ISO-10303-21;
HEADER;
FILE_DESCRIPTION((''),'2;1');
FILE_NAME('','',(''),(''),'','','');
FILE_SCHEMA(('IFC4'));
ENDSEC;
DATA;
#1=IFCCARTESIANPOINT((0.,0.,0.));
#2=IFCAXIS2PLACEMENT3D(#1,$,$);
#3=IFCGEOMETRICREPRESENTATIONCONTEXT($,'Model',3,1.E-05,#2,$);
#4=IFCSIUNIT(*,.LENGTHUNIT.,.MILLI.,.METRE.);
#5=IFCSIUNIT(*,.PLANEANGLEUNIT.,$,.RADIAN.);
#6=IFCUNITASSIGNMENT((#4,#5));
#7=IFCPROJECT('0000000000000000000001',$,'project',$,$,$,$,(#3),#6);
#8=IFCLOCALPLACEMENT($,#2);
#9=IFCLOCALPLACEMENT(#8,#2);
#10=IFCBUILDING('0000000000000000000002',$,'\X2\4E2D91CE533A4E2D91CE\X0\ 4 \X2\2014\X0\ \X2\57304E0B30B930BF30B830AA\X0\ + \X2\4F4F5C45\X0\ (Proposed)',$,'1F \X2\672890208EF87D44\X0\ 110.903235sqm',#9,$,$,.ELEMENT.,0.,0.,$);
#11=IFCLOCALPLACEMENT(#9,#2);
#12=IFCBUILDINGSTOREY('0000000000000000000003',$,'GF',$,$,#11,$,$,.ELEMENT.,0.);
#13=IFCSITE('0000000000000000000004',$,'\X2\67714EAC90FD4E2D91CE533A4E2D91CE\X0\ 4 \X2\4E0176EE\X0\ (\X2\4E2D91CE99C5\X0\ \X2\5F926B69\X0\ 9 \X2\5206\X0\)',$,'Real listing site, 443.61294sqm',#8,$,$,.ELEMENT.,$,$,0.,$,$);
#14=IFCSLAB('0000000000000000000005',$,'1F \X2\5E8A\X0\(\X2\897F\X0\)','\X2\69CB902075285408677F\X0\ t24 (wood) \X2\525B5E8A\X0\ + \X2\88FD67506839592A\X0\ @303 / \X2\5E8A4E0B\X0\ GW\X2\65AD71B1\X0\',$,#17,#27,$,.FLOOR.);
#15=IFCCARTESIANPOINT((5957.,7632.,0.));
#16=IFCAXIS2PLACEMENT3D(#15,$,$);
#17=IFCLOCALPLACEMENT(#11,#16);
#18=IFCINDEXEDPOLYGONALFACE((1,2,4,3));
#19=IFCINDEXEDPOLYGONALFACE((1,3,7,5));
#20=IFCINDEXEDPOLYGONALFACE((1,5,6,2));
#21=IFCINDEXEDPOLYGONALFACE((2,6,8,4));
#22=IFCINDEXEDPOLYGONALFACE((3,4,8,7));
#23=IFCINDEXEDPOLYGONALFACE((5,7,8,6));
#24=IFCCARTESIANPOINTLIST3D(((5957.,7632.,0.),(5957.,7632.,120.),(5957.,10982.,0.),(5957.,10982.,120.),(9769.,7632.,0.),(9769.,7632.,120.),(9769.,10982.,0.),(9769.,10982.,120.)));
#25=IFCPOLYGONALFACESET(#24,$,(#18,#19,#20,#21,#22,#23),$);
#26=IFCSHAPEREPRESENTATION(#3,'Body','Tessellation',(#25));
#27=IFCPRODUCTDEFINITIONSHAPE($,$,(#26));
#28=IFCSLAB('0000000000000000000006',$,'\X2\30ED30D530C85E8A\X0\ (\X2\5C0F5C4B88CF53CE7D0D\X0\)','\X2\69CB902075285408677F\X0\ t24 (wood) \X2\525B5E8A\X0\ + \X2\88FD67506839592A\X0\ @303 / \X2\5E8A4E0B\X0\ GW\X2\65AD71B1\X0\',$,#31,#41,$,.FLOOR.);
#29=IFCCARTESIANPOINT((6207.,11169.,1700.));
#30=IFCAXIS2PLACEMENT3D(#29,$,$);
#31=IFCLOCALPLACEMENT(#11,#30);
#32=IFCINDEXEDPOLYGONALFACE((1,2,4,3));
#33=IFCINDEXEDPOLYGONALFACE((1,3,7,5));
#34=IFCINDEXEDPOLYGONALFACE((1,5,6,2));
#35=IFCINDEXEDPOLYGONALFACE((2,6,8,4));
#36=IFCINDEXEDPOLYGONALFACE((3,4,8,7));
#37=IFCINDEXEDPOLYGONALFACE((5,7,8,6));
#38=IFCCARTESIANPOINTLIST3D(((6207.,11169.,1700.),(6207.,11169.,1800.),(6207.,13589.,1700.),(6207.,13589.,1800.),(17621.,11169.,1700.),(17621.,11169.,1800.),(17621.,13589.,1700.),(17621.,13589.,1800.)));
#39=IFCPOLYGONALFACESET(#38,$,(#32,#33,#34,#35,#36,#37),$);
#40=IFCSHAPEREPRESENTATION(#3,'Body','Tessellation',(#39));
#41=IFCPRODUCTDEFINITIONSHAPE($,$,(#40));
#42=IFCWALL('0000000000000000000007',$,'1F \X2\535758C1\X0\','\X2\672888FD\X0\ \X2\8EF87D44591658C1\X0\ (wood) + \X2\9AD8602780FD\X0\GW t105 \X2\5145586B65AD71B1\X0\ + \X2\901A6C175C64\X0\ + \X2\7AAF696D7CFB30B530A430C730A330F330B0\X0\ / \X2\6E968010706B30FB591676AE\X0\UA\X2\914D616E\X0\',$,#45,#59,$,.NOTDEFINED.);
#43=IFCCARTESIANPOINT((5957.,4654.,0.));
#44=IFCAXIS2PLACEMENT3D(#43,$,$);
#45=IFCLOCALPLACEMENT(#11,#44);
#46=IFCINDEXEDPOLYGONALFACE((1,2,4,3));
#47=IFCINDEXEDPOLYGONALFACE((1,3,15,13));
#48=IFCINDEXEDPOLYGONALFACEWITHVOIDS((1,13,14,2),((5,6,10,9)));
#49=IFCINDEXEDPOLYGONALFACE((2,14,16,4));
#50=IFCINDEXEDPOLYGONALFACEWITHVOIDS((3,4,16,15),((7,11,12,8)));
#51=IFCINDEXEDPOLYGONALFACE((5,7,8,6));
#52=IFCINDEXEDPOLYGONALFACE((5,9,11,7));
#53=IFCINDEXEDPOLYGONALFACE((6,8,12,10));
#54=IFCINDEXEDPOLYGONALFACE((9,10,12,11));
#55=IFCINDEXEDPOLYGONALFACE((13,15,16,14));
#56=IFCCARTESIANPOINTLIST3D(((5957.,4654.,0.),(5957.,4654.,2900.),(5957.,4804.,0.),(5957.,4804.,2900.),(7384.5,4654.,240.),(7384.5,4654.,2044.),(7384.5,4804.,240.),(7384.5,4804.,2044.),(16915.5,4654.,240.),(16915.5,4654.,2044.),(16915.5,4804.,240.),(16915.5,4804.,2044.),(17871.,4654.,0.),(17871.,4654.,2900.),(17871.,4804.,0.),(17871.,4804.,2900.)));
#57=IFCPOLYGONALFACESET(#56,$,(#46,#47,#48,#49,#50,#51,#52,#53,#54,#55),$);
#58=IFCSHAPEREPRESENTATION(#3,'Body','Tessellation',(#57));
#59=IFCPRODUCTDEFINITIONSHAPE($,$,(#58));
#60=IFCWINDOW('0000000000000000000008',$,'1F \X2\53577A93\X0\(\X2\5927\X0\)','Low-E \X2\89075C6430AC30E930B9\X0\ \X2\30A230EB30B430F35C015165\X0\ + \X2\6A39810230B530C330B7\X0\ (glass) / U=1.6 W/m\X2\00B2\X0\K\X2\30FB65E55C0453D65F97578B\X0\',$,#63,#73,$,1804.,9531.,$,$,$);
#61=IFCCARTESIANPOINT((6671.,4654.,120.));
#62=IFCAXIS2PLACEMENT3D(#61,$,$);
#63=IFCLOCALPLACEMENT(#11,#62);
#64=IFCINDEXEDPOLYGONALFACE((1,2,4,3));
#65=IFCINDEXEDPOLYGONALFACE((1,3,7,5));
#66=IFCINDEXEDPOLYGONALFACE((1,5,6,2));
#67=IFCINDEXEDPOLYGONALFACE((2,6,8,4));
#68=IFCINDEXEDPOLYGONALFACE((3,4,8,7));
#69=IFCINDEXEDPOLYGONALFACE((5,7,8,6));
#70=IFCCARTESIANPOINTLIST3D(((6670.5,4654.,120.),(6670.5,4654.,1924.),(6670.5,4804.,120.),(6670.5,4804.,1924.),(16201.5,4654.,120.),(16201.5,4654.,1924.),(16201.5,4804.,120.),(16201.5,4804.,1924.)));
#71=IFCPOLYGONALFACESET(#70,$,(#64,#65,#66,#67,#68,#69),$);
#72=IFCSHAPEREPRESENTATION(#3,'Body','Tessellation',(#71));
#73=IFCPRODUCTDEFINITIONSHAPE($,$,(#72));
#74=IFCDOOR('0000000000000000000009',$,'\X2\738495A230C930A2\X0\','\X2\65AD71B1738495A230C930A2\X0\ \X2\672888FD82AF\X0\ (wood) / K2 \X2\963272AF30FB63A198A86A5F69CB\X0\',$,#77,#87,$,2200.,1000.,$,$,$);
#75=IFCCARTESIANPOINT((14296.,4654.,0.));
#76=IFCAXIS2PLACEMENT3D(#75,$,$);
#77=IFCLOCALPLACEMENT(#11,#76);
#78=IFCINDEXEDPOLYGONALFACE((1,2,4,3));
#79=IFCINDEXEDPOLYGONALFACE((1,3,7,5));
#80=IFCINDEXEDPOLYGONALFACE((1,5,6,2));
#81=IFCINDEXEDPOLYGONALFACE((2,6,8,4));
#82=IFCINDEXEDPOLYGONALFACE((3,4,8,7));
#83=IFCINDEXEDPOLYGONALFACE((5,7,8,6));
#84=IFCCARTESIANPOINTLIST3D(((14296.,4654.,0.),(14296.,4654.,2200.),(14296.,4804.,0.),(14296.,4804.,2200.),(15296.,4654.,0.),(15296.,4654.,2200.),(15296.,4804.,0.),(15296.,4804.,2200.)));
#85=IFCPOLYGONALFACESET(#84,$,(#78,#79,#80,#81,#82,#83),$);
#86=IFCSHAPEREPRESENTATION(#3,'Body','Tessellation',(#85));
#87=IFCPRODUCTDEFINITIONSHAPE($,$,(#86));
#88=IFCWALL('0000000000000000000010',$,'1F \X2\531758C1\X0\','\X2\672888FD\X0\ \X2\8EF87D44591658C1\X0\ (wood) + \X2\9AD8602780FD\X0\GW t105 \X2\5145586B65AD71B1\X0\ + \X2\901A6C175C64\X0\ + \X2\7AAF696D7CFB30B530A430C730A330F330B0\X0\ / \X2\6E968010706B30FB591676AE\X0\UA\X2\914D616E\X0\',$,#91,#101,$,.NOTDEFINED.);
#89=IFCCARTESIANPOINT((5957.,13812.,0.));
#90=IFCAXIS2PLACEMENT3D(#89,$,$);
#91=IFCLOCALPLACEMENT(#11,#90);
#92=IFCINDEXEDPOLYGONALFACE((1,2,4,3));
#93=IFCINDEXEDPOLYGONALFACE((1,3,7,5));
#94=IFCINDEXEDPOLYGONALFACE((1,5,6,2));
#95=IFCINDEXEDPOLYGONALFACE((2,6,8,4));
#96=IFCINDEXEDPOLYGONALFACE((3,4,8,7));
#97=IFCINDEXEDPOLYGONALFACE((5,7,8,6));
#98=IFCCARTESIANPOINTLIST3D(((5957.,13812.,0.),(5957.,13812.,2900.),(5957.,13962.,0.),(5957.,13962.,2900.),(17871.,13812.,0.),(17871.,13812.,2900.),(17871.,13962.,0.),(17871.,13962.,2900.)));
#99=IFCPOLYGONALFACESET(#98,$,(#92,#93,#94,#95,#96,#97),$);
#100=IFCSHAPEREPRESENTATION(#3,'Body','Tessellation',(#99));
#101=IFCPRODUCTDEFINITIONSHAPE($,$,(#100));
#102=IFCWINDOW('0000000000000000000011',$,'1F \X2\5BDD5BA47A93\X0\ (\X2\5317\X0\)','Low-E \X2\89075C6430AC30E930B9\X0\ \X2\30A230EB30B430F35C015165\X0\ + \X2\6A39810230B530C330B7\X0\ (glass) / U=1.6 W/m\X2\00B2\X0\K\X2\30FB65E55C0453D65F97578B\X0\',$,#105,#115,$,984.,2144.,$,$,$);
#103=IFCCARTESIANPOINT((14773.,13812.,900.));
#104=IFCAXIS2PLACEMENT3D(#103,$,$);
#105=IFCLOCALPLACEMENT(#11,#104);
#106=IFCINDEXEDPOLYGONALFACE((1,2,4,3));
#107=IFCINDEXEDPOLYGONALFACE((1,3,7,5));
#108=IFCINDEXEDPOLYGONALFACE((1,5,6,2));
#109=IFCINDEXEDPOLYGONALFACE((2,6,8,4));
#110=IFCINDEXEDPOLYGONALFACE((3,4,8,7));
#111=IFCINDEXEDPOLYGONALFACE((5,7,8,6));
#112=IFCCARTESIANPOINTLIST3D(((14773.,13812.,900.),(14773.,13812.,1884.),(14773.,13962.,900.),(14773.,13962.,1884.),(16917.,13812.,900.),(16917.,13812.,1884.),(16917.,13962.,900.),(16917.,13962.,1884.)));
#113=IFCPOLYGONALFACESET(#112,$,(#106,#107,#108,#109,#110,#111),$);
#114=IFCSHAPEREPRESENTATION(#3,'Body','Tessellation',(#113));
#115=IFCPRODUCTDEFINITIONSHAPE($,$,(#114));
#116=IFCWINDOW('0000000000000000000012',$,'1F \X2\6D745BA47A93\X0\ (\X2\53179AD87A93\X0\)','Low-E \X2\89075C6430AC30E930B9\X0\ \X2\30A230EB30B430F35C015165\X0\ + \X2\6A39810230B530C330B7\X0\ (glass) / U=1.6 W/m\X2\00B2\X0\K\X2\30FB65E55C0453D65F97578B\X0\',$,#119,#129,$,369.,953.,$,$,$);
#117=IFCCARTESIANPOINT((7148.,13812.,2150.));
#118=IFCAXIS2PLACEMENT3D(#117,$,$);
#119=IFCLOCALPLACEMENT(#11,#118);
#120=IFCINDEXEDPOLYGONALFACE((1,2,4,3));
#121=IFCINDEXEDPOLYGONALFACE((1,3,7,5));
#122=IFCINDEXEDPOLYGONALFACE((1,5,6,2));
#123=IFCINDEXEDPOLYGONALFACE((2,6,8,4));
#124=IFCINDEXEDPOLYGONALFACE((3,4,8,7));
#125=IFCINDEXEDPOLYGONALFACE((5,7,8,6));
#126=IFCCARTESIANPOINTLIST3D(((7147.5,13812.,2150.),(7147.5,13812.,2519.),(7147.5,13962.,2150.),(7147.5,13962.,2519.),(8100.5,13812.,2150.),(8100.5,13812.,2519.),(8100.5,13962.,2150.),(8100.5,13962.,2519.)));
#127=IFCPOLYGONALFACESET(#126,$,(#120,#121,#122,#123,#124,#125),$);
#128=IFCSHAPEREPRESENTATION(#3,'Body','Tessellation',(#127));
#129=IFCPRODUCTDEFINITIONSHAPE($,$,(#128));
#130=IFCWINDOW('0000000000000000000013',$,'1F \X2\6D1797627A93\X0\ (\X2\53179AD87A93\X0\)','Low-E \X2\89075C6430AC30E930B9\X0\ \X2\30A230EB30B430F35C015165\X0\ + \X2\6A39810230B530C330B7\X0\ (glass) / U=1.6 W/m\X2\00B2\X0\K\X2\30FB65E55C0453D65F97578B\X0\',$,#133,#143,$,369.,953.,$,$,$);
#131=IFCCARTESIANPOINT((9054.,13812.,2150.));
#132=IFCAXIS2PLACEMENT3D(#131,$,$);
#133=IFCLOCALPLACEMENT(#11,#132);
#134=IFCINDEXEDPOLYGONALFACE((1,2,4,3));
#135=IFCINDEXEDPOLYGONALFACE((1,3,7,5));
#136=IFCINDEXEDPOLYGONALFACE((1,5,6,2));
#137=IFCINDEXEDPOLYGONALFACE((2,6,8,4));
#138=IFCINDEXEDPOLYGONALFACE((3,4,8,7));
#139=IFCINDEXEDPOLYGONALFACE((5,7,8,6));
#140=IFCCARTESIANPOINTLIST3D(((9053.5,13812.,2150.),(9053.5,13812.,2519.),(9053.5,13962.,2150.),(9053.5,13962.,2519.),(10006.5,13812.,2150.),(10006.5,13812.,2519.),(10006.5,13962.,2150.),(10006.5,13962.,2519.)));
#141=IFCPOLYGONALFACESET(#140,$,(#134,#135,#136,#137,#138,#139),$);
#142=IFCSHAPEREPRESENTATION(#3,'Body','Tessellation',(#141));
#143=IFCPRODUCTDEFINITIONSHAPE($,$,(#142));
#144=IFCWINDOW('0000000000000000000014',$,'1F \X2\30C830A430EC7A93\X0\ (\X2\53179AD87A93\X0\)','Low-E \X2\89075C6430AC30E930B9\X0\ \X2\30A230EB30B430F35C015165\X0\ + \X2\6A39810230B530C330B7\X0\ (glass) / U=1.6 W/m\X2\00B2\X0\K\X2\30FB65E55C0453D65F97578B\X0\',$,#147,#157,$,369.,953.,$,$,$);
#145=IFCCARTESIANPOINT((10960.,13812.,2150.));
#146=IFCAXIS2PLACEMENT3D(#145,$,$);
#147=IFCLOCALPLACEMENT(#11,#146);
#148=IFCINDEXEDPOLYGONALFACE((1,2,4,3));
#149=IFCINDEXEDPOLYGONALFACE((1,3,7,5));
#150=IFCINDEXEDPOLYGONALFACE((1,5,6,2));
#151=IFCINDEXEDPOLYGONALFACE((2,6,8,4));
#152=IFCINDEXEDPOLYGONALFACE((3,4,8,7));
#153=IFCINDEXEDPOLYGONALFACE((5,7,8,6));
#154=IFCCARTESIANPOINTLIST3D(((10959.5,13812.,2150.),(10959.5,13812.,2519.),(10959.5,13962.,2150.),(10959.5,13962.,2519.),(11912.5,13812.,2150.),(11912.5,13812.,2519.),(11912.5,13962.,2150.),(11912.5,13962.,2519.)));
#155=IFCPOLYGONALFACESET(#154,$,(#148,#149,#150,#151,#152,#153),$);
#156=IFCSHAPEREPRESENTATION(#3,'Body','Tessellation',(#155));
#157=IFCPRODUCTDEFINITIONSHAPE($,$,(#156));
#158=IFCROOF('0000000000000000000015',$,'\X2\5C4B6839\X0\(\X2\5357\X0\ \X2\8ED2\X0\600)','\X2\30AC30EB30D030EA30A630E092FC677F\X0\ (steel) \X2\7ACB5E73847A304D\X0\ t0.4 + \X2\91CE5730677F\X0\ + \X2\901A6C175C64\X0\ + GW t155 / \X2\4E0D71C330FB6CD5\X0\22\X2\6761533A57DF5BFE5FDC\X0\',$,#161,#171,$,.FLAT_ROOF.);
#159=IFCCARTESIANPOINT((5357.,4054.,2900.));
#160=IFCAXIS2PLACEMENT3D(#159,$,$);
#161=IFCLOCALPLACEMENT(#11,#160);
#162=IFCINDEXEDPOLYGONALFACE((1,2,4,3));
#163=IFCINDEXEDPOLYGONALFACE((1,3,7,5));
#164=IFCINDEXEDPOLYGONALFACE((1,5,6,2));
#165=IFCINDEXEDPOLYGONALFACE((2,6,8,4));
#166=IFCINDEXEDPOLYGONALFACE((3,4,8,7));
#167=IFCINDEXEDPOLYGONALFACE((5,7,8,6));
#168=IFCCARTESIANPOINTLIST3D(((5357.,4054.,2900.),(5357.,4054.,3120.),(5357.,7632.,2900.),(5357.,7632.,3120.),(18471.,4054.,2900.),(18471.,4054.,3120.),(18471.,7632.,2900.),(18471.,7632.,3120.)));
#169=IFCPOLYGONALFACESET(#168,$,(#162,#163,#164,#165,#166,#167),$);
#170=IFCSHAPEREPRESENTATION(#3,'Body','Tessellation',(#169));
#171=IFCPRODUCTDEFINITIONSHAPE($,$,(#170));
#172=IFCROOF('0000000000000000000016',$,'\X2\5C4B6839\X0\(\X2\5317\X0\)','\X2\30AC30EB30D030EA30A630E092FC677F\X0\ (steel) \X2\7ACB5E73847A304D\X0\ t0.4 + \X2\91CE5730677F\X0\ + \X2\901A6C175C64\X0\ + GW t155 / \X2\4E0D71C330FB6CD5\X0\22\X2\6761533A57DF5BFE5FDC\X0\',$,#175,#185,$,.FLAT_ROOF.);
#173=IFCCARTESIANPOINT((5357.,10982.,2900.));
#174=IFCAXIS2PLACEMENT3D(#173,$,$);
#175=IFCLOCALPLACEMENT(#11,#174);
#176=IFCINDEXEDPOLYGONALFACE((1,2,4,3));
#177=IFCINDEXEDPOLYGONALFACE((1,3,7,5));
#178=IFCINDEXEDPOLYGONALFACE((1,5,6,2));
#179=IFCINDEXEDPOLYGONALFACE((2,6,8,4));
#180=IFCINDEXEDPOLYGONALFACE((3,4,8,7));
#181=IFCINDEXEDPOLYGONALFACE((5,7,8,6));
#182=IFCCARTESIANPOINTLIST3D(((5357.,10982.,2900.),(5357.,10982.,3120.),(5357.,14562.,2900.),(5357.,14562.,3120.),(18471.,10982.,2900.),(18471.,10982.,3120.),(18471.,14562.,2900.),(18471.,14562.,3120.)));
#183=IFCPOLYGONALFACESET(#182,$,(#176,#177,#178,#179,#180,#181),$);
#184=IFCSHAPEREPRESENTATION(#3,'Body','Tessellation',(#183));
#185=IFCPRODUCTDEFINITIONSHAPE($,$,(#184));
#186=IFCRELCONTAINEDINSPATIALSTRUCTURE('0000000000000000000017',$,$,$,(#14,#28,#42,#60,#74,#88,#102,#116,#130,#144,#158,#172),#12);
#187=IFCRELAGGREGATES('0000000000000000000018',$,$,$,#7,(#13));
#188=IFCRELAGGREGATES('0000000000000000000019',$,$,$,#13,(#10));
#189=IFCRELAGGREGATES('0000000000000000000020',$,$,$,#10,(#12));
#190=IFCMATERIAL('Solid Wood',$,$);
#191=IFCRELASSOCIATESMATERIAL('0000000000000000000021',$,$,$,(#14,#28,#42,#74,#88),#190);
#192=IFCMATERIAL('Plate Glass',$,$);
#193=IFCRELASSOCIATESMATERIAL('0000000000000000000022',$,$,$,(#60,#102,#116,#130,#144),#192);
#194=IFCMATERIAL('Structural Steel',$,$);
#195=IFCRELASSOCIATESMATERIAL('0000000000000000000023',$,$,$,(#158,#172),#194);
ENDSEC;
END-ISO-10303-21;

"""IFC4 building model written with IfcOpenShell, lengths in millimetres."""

from ifc_helpers import new_model, si_unit, frame, frame_2d, origin, place, context, project, spatial, rectangle, extrude, material, element, fill, save


model = new_model("IFC4")

# Units and contexts
model_context = context("Model", 3, precision=1e-05, world=origin())
ifc_project = project(units=[si_unit("LENGTHUNIT", "METRE", prefix="MILLI"), si_unit("PLANEANGLEUNIT", "RADIAN")], contexts=[model_context])

# Site, building, storey
site_placement = place(None, origin())
site = spatial("IfcSite", under=ifc_project, at=site_placement, Name="東京都中野区中野 4 丁目 (中野駅 徒歩 9 分)", ObjectType="Real listing site, 443.61294sqm", CompositionType="ELEMENT", RefElevation=0.0)
building_placement = place(site_placement, origin())
building = spatial("IfcBuilding", under=site, at=building_placement, Name="中野区中野 4 — 地下スタジオ + 住居 (Proposed)", ObjectType="1F 木造軸組 110.903235sqm", CompositionType="ELEMENT", ElevationOfRefHeight=0.0, ElevationOfTerrain=0.0)
storey_placement = place(building_placement, origin())
storey = spatial("IfcBuildingStorey", under=building, at=storey_placement, Name="GF", CompositionType="ELEMENT", Elevation=0.0)

# Slabs
ifc_material_1 = material(Name="Solid Wood")
slab_1_placement = place(storey_placement, frame((5957.0, 7632.0, 0.0)))
element("IfcSlab", 1, at=slab_1_placement, inside=storey, material=ifc_material_1, Name="1F 床(西)", Description="構造用合板 t24 (wood) 剛床 + 製材根太 @303 / 床下 GW断熱", PredefinedType="FLOOR", context=model_context, shape_type="SweptSolid", body=[
    extrude(rectangle(XDim=3812.0, YDim=3350.0, at=frame_2d((1906.0, 1675.0))), frame((5957.0, 7632.0, 0.0)), (0.0, 0.0, 1.0), 120.0),
])
slab_2_placement = place(storey_placement, frame((6207.0, 11169.0, 1700.0)))
element("IfcSlab", 2, at=slab_2_placement, inside=storey, material=ifc_material_1, Name="ロフト床 (小屋裏収納)", Description="構造用合板 t24 (wood) 剛床 + 製材根太 @303 / 床下 GW断熱", PredefinedType="FLOOR", context=model_context, shape_type="SweptSolid", body=[
    extrude(rectangle(XDim=11414.0, YDim=2420.0, at=frame_2d((5707.0, 1210.0))), frame((6207.0, 11169.0, 1700.0)), (0.0, 0.0, 1.0), 100.0),
])

# Wall, openings, window, door
wall_1_placement = place(storey_placement, frame((5957.0, 4654.0, 0.0)))
wall_1 = element("IfcWall", 3, at=wall_1_placement, inside=storey, material=ifc_material_1, Name="1F 南壁", Description="木製 軸組外壁 (wood) + 高性能GW t105 充填断熱 + 通気層 + 窯業系サイディング / 準耐火・外皮UA配慮", PredefinedType="NOTDEFINED", context=model_context, shape_type="SweptSolid", body=[
    extrude(rectangle(XDim=11914.0, YDim=150.0, at=frame_2d((5957.0, 75.0))), frame((5957.0, 4654.0, 0.0)), (0.0, 0.0, 1.0), 2900.0),
])
opening_1_placement = place(storey_placement, frame((6671.0, 4654.0, 120.0)))
opening_1 = element("IfcOpeningElement", 4, at=opening_1_placement, cuts=wall_1, PredefinedType="NOTDEFINED", context=model_context, shape_type="SweptSolid", body=[
    extrude(rectangle(XDim=9531.0, YDim=150.0, at=frame_2d((4765.0, 75.0))), frame((6671.0, 4654.0, 120.0)), (0.0, 0.0, 1.0), 1804.0),
])
opening_2_placement = place(storey_placement, frame((14296.0, 4654.0, 0.0)))
opening_2 = element("IfcOpeningElement", 5, at=opening_2_placement, cuts=wall_1, PredefinedType="NOTDEFINED", context=model_context, shape_type="SweptSolid", body=[
    extrude(rectangle(XDim=1000.0, YDim=150.0, at=frame_2d((500.0, 75.0))), frame((14296.0, 4654.0, 0.0)), (0.0, 0.0, 1.0), 2200.0),
])
ifc_material_2 = material(Name="Plate Glass")
window_1_placement = place(storey_placement, frame((6671.0, 4654.0, 120.0)))
window_1 = element("IfcWindow", 6, at=window_1_placement, inside=storey, material=ifc_material_2, Name="1F 南窓(大)", Description="Low-E 複層ガラス アルゴン封入 + 樹脂サッシ (glass) / U=1.6 W/m²K・日射取得型", OverallHeight=1804.0, OverallWidth=9531.0, context=model_context, shape_type="SweptSolid", body=[
    extrude(rectangle(XDim=9531.0, YDim=150.0, at=frame_2d((4765.0, 75.0))), frame((6671.0, 4654.0, 120.0)), (0.0, 0.0, 1.0), 1804.0),
])
fill(opening_1, window_1)
door_1_placement = place(storey_placement, frame((14296.0, 4654.0, 0.0)))
door_1 = element("IfcDoor", 7, at=door_1_placement, inside=storey, material=ifc_material_1, Name="玄関ドア", Description="断熱玄関ドア 木製芯 (wood) / K2 防犯・採風機構", OverallHeight=2200.0, OverallWidth=1000.0, context=model_context, shape_type="SweptSolid", body=[
    extrude(rectangle(XDim=1000.0, YDim=150.0, at=frame_2d((500.0, 75.0))), frame((14296.0, 4654.0, 0.0)), (0.0, 0.0, 1.0), 2200.0),
])
fill(opening_2, door_1)

# Wall, openings, windows
wall_2_placement = place(storey_placement, frame((5957.0, 13812.0, 0.0)))
wall_2 = element("IfcWall", 8, at=wall_2_placement, inside=storey, material=ifc_material_1, Name="1F 北壁", Description="木製 軸組外壁 (wood) + 高性能GW t105 充填断熱 + 通気層 + 窯業系サイディング / 準耐火・外皮UA配慮", PredefinedType="NOTDEFINED", context=model_context, shape_type="SweptSolid", body=[
    extrude(rectangle(XDim=11914.0, YDim=150.0, at=frame_2d((5957.0, 75.0))), frame((5957.0, 13812.0, 0.0)), (0.0, 0.0, 1.0), 2900.0),
])
opening_3_placement = place(storey_placement, frame((14773.0, 13812.0, 900.0)))
opening_3 = element("IfcOpeningElement", 9, at=opening_3_placement, cuts=wall_2, PredefinedType="NOTDEFINED", context=model_context, shape_type="SweptSolid", body=[
    extrude(rectangle(XDim=2144.0, YDim=150.0, at=frame_2d((1072.0, 75.0))), frame((14773.0, 13812.0, 900.0)), (0.0, 0.0, 1.0), 984.0),
])
opening_4_placement = place(storey_placement, frame((7148.0, 13812.0, 2150.0)))
opening_4 = element("IfcOpeningElement", 10, at=opening_4_placement, cuts=wall_2, PredefinedType="NOTDEFINED", context=model_context, shape_type="SweptSolid", body=[
    extrude(rectangle(XDim=953.0, YDim=150.0, at=frame_2d((476.0, 75.0))), frame((7148.0, 13812.0, 2150.0)), (0.0, 0.0, 1.0), 369.0),
])
opening_5_placement = place(storey_placement, frame((9054.0, 13812.0, 2150.0)))
opening_5 = element("IfcOpeningElement", 11, at=opening_5_placement, cuts=wall_2, PredefinedType="NOTDEFINED", context=model_context, shape_type="SweptSolid", body=[
    extrude(rectangle(XDim=953.0, YDim=150.0, at=frame_2d((476.0, 75.0))), frame((9054.0, 13812.0, 2150.0)), (0.0, 0.0, 1.0), 369.0),
])
opening_6_placement = place(storey_placement, frame((10960.0, 13812.0, 2150.0)))
opening_6 = element("IfcOpeningElement", 12, at=opening_6_placement, cuts=wall_2, PredefinedType="NOTDEFINED", context=model_context, shape_type="SweptSolid", body=[
    extrude(rectangle(XDim=953.0, YDim=150.0, at=frame_2d((476.0, 75.0))), frame((10960.0, 13812.0, 2150.0)), (0.0, 0.0, 1.0), 369.0),
])
window_2_placement = place(storey_placement, frame((14773.0, 13812.0, 900.0)))
window_2 = element("IfcWindow", 13, at=window_2_placement, inside=storey, material=ifc_material_2, Name="1F 寝室窓 (北)", Description="Low-E 複層ガラス アルゴン封入 + 樹脂サッシ (glass) / U=1.6 W/m²K・日射取得型", OverallHeight=984.0, OverallWidth=2144.0, context=model_context, shape_type="SweptSolid", body=[
    extrude(rectangle(XDim=2144.0, YDim=150.0, at=frame_2d((1072.0, 75.0))), frame((14773.0, 13812.0, 900.0)), (0.0, 0.0, 1.0), 984.0),
])
fill(opening_3, window_2)
window_3_placement = place(storey_placement, frame((7148.0, 13812.0, 2150.0)))
window_3 = element("IfcWindow", 14, at=window_3_placement, inside=storey, material=ifc_material_2, Name="1F 浴室窓 (北高窓)", Description="Low-E 複層ガラス アルゴン封入 + 樹脂サッシ (glass) / U=1.6 W/m²K・日射取得型", OverallHeight=369.0, OverallWidth=953.0, context=model_context, shape_type="SweptSolid", body=[
    extrude(rectangle(XDim=953.0, YDim=150.0, at=frame_2d((476.0, 75.0))), frame((7148.0, 13812.0, 2150.0)), (0.0, 0.0, 1.0), 369.0),
])
fill(opening_4, window_3)
window_4_placement = place(storey_placement, frame((9054.0, 13812.0, 2150.0)))
window_4 = element("IfcWindow", 15, at=window_4_placement, inside=storey, material=ifc_material_2, Name="1F 洗面窓 (北高窓)", Description="Low-E 複層ガラス アルゴン封入 + 樹脂サッシ (glass) / U=1.6 W/m²K・日射取得型", OverallHeight=369.0, OverallWidth=953.0, context=model_context, shape_type="SweptSolid", body=[
    extrude(rectangle(XDim=953.0, YDim=150.0, at=frame_2d((476.0, 75.0))), frame((9054.0, 13812.0, 2150.0)), (0.0, 0.0, 1.0), 369.0),
])
fill(opening_5, window_4)
window_5_placement = place(storey_placement, frame((10960.0, 13812.0, 2150.0)))
window_5 = element("IfcWindow", 16, at=window_5_placement, inside=storey, material=ifc_material_2, Name="1F トイレ窓 (北高窓)", Description="Low-E 複層ガラス アルゴン封入 + 樹脂サッシ (glass) / U=1.6 W/m²K・日射取得型", OverallHeight=369.0, OverallWidth=953.0, context=model_context, shape_type="SweptSolid", body=[
    extrude(rectangle(XDim=953.0, YDim=150.0, at=frame_2d((476.0, 75.0))), frame((10960.0, 13812.0, 2150.0)), (0.0, 0.0, 1.0), 369.0),
])
fill(opening_6, window_5)

# Roofs
ifc_material_3 = material(Name="Structural Steel")
roof_1_placement = place(storey_placement, frame((5357.0, 4054.0, 2900.0)))
element("IfcRoof", 17, at=roof_1_placement, inside=storey, material=ifc_material_3, Name="屋根(南 軒600)", Description="ガルバリウム鋼板 (steel) 立平葺き t0.4 + 野地板 + 通気層 + GW t155 / 不燃・法22条区域対応", PredefinedType="FLAT_ROOF", context=model_context, shape_type="SweptSolid", body=[
    extrude(rectangle(XDim=13114.0, YDim=3578.0, at=frame_2d((6557.0, 1789.0))), frame((5357.0, 4054.0, 2900.0)), (0.0, 0.0, 1.0), 220.0),
])
roof_2_placement = place(storey_placement, frame((5357.0, 10982.0, 2900.0)))
element("IfcRoof", 18, at=roof_2_placement, inside=storey, material=ifc_material_3, Name="屋根(北)", Description="ガルバリウム鋼板 (steel) 立平葺き t0.4 + 野地板 + 通気層 + GW t155 / 不燃・法22条区域対応", PredefinedType="FLAT_ROOF", context=model_context, shape_type="SweptSolid", body=[
    extrude(rectangle(XDim=13114.0, YDim=3580.0, at=frame_2d((6557.0, 1790.0))), frame((5357.0, 10982.0, 2900.0)), (0.0, 0.0, 1.0), 220.0),
])

save(model, "model.ifc")
